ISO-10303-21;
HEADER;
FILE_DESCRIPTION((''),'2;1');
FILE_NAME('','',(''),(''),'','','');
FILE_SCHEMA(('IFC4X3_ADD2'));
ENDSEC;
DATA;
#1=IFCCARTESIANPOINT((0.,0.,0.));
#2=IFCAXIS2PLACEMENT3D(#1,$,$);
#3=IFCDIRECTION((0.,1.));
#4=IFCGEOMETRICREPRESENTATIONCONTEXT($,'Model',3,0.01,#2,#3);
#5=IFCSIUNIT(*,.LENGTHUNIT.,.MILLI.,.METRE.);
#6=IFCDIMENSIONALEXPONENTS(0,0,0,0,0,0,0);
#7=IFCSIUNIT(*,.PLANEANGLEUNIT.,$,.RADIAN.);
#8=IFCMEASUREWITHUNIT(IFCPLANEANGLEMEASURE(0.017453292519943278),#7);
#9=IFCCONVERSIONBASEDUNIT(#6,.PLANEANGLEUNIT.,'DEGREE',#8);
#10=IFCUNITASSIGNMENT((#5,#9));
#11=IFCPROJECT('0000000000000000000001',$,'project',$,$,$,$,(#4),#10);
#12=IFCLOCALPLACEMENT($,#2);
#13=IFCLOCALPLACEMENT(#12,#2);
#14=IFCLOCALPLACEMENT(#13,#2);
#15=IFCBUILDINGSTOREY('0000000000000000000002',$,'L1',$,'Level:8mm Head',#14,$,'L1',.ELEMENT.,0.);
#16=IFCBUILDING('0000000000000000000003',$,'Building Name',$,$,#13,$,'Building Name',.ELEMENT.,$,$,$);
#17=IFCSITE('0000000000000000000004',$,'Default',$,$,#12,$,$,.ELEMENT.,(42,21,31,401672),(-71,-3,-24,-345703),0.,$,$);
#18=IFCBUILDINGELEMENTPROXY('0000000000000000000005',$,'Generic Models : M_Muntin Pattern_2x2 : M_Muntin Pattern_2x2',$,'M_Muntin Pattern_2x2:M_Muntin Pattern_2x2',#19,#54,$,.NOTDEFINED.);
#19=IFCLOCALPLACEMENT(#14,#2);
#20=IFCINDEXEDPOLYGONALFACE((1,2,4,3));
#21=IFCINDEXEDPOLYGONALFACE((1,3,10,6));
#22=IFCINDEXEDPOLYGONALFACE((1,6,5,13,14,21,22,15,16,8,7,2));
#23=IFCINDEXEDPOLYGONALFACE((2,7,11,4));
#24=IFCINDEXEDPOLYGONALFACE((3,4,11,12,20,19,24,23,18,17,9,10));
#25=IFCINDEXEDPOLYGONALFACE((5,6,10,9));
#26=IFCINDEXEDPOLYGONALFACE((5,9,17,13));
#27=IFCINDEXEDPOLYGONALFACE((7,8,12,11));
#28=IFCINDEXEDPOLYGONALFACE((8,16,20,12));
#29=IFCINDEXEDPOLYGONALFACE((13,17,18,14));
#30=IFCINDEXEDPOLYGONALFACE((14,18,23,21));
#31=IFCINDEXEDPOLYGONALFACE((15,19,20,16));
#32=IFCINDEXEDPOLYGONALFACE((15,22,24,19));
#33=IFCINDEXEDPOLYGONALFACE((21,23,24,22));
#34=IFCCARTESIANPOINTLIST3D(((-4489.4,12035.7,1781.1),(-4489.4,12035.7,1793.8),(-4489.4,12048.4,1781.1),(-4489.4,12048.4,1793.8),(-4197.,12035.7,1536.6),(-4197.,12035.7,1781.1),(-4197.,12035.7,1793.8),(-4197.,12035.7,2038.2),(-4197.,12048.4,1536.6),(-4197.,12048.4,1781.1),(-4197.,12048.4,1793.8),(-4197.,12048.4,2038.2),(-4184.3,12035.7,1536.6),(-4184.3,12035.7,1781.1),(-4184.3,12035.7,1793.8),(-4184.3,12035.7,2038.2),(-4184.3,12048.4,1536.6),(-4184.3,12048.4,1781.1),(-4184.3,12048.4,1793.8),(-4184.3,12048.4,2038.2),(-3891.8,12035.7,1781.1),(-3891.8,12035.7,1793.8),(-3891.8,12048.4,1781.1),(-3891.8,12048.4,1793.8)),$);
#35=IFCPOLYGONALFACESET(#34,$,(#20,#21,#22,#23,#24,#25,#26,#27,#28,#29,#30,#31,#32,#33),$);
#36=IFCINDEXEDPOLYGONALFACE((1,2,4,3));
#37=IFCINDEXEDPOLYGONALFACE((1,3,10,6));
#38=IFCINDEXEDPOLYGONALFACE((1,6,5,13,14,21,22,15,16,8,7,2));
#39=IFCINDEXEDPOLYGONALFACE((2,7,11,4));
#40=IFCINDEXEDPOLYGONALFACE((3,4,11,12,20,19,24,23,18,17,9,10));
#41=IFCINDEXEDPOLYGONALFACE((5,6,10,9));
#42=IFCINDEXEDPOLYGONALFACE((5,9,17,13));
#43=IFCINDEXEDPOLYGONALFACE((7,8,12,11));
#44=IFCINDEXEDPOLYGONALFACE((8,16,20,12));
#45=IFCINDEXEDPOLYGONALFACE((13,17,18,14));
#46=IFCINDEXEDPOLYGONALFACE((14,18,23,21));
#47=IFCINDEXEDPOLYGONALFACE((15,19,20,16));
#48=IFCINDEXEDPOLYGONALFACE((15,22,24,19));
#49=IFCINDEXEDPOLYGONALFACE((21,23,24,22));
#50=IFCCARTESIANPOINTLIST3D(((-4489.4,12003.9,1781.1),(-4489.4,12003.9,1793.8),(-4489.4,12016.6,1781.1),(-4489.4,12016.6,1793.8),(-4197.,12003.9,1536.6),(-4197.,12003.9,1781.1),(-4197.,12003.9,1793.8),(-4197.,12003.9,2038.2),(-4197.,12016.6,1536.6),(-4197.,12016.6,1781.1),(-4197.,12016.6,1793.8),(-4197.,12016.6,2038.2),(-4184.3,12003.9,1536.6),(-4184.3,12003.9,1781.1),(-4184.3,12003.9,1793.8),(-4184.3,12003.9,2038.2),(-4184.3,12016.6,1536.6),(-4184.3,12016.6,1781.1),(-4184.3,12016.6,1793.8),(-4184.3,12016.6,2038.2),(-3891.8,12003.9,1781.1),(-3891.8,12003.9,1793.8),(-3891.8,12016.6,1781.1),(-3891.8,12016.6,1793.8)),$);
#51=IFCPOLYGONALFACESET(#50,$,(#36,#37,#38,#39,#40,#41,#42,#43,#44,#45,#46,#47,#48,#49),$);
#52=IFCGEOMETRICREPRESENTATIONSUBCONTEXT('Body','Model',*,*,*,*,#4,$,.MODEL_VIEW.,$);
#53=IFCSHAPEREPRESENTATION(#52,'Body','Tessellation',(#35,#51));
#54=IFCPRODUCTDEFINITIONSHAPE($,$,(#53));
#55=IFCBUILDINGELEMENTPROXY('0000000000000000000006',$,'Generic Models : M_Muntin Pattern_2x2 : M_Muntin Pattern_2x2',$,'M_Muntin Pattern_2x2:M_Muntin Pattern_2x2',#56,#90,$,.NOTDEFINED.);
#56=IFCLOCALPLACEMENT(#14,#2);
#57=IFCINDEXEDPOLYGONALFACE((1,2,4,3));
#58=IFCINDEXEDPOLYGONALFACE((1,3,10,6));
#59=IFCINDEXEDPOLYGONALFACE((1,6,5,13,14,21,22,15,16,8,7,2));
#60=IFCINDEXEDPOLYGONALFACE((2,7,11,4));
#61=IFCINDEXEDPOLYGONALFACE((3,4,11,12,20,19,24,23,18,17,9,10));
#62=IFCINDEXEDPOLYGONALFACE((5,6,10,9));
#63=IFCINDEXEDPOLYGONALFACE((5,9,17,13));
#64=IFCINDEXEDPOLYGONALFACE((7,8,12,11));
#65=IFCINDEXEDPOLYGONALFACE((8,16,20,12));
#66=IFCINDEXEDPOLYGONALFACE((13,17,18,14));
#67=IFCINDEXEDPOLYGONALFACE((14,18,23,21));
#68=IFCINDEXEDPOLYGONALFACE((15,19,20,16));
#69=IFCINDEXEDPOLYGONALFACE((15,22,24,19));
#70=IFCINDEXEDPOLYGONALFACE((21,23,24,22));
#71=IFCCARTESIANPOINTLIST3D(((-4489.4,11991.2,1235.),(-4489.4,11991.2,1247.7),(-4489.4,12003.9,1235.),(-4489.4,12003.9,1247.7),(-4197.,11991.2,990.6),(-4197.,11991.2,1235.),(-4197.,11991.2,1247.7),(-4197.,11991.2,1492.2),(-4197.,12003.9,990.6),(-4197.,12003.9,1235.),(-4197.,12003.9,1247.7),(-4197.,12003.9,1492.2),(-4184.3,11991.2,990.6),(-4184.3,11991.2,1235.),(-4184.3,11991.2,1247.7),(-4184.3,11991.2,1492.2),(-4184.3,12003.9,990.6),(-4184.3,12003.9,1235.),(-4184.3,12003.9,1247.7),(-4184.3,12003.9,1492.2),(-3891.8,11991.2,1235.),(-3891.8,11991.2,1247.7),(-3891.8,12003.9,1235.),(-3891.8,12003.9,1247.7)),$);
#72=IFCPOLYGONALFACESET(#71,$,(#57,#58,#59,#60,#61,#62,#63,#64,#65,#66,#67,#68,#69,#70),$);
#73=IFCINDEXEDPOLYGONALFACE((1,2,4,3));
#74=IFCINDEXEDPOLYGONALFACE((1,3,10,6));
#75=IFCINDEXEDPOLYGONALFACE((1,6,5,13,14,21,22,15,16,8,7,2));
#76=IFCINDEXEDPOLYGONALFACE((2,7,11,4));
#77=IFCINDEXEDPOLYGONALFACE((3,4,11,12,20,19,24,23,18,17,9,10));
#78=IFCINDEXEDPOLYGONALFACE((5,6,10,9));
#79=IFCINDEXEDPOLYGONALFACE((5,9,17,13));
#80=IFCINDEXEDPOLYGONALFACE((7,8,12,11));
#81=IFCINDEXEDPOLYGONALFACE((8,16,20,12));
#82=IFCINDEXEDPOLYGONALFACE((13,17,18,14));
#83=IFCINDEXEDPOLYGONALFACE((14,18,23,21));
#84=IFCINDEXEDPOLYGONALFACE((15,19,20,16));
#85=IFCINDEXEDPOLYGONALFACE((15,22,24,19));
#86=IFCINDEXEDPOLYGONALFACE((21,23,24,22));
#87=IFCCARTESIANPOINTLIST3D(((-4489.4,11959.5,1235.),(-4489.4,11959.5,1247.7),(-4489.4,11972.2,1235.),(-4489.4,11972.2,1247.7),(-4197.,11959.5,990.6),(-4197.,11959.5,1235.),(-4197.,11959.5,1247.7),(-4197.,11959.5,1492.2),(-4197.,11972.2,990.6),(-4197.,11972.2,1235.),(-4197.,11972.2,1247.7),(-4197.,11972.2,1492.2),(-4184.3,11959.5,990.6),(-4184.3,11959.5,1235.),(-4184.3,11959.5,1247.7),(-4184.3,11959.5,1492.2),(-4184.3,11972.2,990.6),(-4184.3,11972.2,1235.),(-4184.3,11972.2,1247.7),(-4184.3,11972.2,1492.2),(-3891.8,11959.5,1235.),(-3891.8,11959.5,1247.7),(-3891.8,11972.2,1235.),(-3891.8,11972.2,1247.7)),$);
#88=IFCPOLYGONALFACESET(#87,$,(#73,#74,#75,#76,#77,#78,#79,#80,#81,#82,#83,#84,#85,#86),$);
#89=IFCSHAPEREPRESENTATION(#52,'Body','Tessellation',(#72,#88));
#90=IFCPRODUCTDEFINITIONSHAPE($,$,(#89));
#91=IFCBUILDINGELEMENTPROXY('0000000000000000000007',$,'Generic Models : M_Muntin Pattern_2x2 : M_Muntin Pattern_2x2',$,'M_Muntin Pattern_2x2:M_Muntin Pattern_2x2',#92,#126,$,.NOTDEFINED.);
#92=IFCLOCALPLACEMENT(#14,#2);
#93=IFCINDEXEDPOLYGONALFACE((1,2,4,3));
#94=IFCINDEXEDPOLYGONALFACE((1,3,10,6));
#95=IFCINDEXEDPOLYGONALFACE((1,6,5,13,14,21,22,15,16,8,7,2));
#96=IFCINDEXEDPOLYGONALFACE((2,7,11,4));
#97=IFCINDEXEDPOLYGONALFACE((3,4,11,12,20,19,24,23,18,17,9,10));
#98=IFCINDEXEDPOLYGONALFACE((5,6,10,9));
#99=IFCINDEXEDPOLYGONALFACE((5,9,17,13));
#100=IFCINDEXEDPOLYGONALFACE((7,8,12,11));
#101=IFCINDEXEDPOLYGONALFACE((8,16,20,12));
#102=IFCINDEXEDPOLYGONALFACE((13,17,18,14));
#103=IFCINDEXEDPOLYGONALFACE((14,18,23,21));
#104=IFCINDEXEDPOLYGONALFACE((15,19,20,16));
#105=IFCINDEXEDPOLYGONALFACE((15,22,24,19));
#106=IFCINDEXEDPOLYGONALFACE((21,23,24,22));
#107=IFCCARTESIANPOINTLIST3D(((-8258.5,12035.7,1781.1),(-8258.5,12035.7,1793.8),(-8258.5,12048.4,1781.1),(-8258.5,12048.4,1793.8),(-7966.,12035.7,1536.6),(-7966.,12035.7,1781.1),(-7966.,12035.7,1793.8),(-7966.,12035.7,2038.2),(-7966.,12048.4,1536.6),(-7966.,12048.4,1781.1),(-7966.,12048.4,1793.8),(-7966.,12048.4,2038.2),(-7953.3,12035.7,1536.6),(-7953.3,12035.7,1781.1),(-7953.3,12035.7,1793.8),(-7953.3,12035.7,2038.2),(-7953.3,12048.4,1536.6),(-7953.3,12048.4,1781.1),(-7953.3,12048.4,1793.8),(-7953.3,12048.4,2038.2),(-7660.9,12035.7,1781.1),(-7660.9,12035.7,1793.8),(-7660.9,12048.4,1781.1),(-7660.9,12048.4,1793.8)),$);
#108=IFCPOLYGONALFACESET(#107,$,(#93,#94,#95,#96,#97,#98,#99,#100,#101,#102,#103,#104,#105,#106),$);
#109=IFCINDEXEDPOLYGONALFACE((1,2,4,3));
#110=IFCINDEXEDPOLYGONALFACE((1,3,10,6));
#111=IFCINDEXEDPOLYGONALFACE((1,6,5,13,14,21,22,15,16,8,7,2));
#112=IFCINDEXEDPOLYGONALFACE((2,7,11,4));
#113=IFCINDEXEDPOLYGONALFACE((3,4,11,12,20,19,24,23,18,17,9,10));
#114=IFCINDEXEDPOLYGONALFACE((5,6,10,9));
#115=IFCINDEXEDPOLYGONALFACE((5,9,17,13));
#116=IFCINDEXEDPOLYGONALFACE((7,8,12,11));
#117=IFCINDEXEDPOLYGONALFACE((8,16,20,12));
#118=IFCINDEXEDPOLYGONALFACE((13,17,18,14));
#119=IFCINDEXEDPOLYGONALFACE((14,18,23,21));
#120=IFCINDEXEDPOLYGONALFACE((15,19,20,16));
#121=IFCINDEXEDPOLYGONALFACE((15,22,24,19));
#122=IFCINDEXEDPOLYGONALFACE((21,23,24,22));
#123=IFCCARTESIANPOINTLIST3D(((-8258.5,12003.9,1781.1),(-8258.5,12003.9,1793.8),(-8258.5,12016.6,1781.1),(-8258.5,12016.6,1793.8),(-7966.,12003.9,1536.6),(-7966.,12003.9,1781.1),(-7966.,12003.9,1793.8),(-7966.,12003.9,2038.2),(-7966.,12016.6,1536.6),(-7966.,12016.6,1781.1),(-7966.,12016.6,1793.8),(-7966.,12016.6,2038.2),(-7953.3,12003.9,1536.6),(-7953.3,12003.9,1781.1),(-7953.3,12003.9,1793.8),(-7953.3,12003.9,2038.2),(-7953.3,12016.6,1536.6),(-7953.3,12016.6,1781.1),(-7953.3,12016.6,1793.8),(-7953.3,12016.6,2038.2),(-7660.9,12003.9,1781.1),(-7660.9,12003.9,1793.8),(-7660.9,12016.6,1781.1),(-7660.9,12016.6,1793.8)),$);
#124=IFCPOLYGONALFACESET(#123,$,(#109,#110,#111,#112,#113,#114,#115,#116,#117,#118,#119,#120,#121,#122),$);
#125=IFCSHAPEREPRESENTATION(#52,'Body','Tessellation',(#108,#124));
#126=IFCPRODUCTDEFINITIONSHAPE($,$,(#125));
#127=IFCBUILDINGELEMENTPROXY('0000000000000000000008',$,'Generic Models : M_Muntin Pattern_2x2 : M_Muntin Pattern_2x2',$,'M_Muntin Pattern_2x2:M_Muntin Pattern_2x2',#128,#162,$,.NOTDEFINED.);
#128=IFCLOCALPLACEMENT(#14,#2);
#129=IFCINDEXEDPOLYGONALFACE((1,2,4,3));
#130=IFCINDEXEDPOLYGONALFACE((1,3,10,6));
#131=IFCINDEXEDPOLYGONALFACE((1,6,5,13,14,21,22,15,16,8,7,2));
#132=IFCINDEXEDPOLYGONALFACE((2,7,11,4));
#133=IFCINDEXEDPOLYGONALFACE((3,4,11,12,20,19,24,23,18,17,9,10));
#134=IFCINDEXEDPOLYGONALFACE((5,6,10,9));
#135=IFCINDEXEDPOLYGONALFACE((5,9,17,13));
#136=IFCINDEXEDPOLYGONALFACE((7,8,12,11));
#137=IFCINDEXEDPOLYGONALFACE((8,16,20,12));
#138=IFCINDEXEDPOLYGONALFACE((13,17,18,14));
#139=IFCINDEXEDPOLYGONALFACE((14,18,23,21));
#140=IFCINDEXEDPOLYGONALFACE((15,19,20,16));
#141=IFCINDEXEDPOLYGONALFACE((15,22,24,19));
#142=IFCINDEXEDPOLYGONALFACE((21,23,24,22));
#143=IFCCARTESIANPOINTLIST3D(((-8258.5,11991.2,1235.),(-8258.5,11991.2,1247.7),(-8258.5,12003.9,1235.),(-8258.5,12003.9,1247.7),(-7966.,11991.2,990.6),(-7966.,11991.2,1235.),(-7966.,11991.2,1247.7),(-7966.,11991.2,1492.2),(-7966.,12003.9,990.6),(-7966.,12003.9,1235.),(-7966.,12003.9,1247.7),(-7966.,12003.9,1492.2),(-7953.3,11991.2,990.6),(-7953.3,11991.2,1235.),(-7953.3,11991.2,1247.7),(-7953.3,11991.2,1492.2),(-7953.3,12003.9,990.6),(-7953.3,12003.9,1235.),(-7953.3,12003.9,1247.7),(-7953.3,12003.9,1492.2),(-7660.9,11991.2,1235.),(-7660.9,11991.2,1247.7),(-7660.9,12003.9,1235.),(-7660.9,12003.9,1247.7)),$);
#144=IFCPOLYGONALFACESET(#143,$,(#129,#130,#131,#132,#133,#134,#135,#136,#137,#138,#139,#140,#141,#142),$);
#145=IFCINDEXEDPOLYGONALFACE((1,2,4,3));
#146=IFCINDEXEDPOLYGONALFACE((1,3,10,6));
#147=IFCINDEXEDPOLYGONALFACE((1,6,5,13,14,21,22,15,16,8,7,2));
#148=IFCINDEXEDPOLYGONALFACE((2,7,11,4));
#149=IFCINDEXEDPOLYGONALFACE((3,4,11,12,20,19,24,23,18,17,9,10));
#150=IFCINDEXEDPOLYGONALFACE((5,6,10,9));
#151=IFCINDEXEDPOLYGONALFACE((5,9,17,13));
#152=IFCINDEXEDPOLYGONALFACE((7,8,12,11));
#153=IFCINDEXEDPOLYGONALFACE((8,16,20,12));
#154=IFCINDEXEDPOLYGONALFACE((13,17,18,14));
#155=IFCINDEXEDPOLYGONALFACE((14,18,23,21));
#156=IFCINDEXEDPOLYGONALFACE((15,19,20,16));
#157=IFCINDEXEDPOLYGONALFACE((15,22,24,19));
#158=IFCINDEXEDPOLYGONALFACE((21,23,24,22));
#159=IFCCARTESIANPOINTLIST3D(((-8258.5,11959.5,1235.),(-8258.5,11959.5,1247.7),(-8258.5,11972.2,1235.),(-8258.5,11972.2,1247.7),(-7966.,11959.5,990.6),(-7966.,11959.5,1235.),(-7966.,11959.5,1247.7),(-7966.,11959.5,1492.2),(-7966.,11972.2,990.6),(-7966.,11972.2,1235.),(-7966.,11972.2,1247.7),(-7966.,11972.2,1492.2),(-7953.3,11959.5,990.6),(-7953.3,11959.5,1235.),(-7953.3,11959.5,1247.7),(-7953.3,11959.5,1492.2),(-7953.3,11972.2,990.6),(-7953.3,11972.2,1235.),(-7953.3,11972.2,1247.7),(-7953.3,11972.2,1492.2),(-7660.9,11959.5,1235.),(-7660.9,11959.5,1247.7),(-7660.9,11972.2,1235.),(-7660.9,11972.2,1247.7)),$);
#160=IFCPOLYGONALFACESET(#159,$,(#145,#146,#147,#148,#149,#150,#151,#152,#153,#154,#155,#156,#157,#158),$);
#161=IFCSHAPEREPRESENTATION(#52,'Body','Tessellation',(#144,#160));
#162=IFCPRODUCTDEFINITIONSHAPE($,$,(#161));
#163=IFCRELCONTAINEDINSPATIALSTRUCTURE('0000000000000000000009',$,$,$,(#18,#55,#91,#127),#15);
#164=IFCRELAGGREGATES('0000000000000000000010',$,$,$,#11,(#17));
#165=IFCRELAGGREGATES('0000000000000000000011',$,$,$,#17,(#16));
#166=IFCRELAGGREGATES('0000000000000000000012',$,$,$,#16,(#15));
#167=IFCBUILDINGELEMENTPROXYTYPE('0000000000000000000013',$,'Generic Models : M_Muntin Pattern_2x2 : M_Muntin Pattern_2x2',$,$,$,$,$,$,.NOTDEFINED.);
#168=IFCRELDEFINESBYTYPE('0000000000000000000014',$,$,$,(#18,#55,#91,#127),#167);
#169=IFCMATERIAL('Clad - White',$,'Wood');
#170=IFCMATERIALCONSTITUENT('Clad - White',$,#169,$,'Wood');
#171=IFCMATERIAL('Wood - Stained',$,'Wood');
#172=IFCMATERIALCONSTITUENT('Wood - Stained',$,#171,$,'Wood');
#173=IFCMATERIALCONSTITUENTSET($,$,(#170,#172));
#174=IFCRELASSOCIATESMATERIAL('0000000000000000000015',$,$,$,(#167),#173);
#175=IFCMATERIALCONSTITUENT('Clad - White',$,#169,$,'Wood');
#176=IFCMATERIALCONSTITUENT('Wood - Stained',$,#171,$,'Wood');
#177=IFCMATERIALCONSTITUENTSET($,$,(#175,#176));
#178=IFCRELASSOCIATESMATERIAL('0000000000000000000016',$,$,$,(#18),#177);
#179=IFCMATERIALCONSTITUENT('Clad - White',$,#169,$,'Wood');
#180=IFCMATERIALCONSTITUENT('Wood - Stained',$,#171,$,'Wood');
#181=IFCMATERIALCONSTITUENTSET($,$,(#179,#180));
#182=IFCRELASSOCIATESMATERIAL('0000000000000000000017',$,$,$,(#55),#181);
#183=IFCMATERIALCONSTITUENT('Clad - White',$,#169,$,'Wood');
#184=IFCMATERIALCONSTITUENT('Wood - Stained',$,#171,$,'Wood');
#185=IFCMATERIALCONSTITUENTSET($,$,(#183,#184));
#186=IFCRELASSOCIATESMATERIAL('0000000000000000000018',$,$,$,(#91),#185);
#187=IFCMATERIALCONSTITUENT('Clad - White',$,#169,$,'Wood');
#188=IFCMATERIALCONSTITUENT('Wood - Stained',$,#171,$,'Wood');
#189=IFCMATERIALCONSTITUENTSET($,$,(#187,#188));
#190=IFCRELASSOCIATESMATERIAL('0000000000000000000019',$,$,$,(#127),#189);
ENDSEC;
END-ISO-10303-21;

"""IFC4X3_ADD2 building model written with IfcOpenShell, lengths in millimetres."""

from ifc_helpers import new_model, entity, si_unit, converted_unit, direction, frame, origin, place, context, subcontext, project, spatial, polyline, outline, extrude, source, transform, mapped, material, constituent, constituent_set, type_object, type_shapes, element, save


model = new_model("IFC4X3_ADD2")

# Units and contexts
model_context = context("Model", 3, precision=0.01, world=origin(), true_north=direction((0.0, 1.0)))
body_context = subcontext(model_context, "Body", "Model", "MODEL_VIEW")
ifc_project = project(units=[si_unit("LENGTHUNIT", "METRE", prefix="MILLI"), converted_unit("PLANEANGLEUNIT", "DEGREE", entity("IfcPlaneAngleMeasure", 0.017453292519943278), si_unit("PLANEANGLEUNIT", "RADIAN"), dimensions=[0, 0, 0, 0, 0, 0, 0])], contexts=[model_context])

# Site, building, storey
site_placement = place(None, origin())
site = spatial("IfcSite", under=ifc_project, at=site_placement, Name="Default", CompositionType="ELEMENT", RefLatitude=(42, 21, 31, 401672), RefLongitude=(-71, -3, -24, -345703), RefElevation=0.0)
building_placement = place(site_placement, origin())
building = spatial("IfcBuilding", under=site, at=building_placement, Name="Building Name", LongName="Building Name", CompositionType="ELEMENT")
storey_placement = place(building_placement, origin())
storey = spatial("IfcBuildingStorey", under=building, at=storey_placement, Name="L1", ObjectType="Level:8mm Head", LongName="L1", CompositionType="ELEMENT", Elevation=0.0)

# Shared definitions
ifc_material_1 = material(Name="Wood - Stained", Category="Wood")

# Building element proxies
ifc_material_2 = material(Name="Clad - White", Category="Wood")
ifc_constituent_1 = constituent(ifc_material_2, Name="Clad - White", Category="Wood")
ifc_constituent_2 = constituent(ifc_material_1, Name="Wood - Stained", Category="Wood")
ifc_constituent_set_1 = constituent_set(constituents=[ifc_constituent_1, ifc_constituent_2])
building_element_proxy_type_1 = type_object("IfcBuildingElementProxyType", Name="Generic Models : M_Muntin Pattern_2x2 : M_Muntin Pattern_2x2", PredefinedType="NOTDEFINED", material=ifc_constituent_set_1)
shared_shape_1 = source(origin(), body_context, "Body", "SweptSolid", [
    extrude(outline(polyline([(6.4, -6.4), (250.8, -6.4), (250.8, 6.3), (6.4, 6.3), (6.4, 298.8), (-6.3, 298.8), (-6.3, 6.3), (-250.8, 6.3), (-250.8, -6.4), (-6.3, -6.4), (-6.3, -298.8), (6.4, -298.8), (6.4, -6.4)])), frame((0.0, 9.5, 250.8), z_axis=(0.0, 1.0, 0.0), x_axis=(0.0, 0.0, 1.0)), (0.0, 0.0, 1.0), 12.7),
    extrude(outline(polyline([(6.4, -6.4), (250.8, -6.4), (250.8, 6.3), (6.4, 6.3), (6.4, 298.8), (-6.3, 298.8), (-6.3, 6.3), (-250.8, 6.3), (-250.8, -6.4), (-6.3, -6.4), (-6.3, -298.8), (6.4, -298.8), (6.4, -6.4)])), frame((0.0, -22.2, 250.8), z_axis=(0.0, 1.0, 0.0), x_axis=(0.0, 0.0, 1.0)), (0.0, 0.0, 1.0), 12.7),
])
type_shapes(building_element_proxy_type_1, [shared_shape_1])
ifc_constituent_3 = constituent(ifc_material_2, Name="Clad - White", Category="Wood")
ifc_constituent_4 = constituent(ifc_material_1, Name="Wood - Stained", Category="Wood")
ifc_constituent_set_2 = constituent_set(constituents=[ifc_constituent_3, ifc_constituent_4])
proxy_1_placement = place(storey_placement, frame((-4190.6, 12026.1, 1536.6)))
element("IfcBuildingElementProxy", 1, at=proxy_1_placement, inside=storey, type_object=building_element_proxy_type_1, material=ifc_constituent_set_2, Name="Generic Models : M_Muntin Pattern_2x2 : M_Muntin Pattern_2x2", ObjectType="M_Muntin Pattern_2x2:M_Muntin Pattern_2x2", PredefinedType="NOTDEFINED", context=body_context, shape_type="MappedRepresentation", body=[
    mapped(shared_shape_1, transform((0.0, 0.0, 0.0), scale=1.0)),
])
ifc_constituent_5 = constituent(ifc_material_2, Name="Clad - White", Category="Wood")
ifc_constituent_6 = constituent(ifc_material_1, Name="Wood - Stained", Category="Wood")
ifc_constituent_set_3 = constituent_set(constituents=[ifc_constituent_5, ifc_constituent_6])
proxy_2_placement = place(storey_placement, frame((-4190.6, 11981.7, 990.6)))
element("IfcBuildingElementProxy", 2, at=proxy_2_placement, inside=storey, type_object=building_element_proxy_type_1, material=ifc_constituent_set_3, Name="Generic Models : M_Muntin Pattern_2x2 : M_Muntin Pattern_2x2", ObjectType="M_Muntin Pattern_2x2:M_Muntin Pattern_2x2", PredefinedType="NOTDEFINED", context=body_context, shape_type="MappedRepresentation", body=[
    mapped(shared_shape_1, transform((0.0, 0.0, 0.0), scale=1.0)),
])
ifc_constituent_7 = constituent(ifc_material_2, Name="Clad - White", Category="Wood")
ifc_constituent_8 = constituent(ifc_material_1, Name="Wood - Stained", Category="Wood")
ifc_constituent_set_4 = constituent_set(constituents=[ifc_constituent_7, ifc_constituent_8])
proxy_3_placement = place(storey_placement, frame((-7959.7, 12026.1, 1536.6)))
element("IfcBuildingElementProxy", 3, at=proxy_3_placement, inside=storey, type_object=building_element_proxy_type_1, material=ifc_constituent_set_4, Name="Generic Models : M_Muntin Pattern_2x2 : M_Muntin Pattern_2x2", ObjectType="M_Muntin Pattern_2x2:M_Muntin Pattern_2x2", PredefinedType="NOTDEFINED", context=body_context, shape_type="MappedRepresentation", body=[
    mapped(shared_shape_1, transform((0.0, 0.0, 0.0), scale=1.0)),
])
ifc_constituent_9 = constituent(ifc_material_2, Name="Clad - White", Category="Wood")
ifc_constituent_10 = constituent(ifc_material_1, Name="Wood - Stained", Category="Wood")
ifc_constituent_set_5 = constituent_set(constituents=[ifc_constituent_9, ifc_constituent_10])
proxy_4_placement = place(storey_placement, frame((-7959.7, 11981.7, 990.6)))
element("IfcBuildingElementProxy", 4, at=proxy_4_placement, inside=storey, type_object=building_element_proxy_type_1, material=ifc_constituent_set_5, Name="Generic Models : M_Muntin Pattern_2x2 : M_Muntin Pattern_2x2", ObjectType="M_Muntin Pattern_2x2:M_Muntin Pattern_2x2", PredefinedType="NOTDEFINED", context=body_context, shape_type="MappedRepresentation", body=[
    mapped(shared_shape_1, transform((0.0, 0.0, 0.0), scale=1.0)),
])

save(model, "model.ifc")
